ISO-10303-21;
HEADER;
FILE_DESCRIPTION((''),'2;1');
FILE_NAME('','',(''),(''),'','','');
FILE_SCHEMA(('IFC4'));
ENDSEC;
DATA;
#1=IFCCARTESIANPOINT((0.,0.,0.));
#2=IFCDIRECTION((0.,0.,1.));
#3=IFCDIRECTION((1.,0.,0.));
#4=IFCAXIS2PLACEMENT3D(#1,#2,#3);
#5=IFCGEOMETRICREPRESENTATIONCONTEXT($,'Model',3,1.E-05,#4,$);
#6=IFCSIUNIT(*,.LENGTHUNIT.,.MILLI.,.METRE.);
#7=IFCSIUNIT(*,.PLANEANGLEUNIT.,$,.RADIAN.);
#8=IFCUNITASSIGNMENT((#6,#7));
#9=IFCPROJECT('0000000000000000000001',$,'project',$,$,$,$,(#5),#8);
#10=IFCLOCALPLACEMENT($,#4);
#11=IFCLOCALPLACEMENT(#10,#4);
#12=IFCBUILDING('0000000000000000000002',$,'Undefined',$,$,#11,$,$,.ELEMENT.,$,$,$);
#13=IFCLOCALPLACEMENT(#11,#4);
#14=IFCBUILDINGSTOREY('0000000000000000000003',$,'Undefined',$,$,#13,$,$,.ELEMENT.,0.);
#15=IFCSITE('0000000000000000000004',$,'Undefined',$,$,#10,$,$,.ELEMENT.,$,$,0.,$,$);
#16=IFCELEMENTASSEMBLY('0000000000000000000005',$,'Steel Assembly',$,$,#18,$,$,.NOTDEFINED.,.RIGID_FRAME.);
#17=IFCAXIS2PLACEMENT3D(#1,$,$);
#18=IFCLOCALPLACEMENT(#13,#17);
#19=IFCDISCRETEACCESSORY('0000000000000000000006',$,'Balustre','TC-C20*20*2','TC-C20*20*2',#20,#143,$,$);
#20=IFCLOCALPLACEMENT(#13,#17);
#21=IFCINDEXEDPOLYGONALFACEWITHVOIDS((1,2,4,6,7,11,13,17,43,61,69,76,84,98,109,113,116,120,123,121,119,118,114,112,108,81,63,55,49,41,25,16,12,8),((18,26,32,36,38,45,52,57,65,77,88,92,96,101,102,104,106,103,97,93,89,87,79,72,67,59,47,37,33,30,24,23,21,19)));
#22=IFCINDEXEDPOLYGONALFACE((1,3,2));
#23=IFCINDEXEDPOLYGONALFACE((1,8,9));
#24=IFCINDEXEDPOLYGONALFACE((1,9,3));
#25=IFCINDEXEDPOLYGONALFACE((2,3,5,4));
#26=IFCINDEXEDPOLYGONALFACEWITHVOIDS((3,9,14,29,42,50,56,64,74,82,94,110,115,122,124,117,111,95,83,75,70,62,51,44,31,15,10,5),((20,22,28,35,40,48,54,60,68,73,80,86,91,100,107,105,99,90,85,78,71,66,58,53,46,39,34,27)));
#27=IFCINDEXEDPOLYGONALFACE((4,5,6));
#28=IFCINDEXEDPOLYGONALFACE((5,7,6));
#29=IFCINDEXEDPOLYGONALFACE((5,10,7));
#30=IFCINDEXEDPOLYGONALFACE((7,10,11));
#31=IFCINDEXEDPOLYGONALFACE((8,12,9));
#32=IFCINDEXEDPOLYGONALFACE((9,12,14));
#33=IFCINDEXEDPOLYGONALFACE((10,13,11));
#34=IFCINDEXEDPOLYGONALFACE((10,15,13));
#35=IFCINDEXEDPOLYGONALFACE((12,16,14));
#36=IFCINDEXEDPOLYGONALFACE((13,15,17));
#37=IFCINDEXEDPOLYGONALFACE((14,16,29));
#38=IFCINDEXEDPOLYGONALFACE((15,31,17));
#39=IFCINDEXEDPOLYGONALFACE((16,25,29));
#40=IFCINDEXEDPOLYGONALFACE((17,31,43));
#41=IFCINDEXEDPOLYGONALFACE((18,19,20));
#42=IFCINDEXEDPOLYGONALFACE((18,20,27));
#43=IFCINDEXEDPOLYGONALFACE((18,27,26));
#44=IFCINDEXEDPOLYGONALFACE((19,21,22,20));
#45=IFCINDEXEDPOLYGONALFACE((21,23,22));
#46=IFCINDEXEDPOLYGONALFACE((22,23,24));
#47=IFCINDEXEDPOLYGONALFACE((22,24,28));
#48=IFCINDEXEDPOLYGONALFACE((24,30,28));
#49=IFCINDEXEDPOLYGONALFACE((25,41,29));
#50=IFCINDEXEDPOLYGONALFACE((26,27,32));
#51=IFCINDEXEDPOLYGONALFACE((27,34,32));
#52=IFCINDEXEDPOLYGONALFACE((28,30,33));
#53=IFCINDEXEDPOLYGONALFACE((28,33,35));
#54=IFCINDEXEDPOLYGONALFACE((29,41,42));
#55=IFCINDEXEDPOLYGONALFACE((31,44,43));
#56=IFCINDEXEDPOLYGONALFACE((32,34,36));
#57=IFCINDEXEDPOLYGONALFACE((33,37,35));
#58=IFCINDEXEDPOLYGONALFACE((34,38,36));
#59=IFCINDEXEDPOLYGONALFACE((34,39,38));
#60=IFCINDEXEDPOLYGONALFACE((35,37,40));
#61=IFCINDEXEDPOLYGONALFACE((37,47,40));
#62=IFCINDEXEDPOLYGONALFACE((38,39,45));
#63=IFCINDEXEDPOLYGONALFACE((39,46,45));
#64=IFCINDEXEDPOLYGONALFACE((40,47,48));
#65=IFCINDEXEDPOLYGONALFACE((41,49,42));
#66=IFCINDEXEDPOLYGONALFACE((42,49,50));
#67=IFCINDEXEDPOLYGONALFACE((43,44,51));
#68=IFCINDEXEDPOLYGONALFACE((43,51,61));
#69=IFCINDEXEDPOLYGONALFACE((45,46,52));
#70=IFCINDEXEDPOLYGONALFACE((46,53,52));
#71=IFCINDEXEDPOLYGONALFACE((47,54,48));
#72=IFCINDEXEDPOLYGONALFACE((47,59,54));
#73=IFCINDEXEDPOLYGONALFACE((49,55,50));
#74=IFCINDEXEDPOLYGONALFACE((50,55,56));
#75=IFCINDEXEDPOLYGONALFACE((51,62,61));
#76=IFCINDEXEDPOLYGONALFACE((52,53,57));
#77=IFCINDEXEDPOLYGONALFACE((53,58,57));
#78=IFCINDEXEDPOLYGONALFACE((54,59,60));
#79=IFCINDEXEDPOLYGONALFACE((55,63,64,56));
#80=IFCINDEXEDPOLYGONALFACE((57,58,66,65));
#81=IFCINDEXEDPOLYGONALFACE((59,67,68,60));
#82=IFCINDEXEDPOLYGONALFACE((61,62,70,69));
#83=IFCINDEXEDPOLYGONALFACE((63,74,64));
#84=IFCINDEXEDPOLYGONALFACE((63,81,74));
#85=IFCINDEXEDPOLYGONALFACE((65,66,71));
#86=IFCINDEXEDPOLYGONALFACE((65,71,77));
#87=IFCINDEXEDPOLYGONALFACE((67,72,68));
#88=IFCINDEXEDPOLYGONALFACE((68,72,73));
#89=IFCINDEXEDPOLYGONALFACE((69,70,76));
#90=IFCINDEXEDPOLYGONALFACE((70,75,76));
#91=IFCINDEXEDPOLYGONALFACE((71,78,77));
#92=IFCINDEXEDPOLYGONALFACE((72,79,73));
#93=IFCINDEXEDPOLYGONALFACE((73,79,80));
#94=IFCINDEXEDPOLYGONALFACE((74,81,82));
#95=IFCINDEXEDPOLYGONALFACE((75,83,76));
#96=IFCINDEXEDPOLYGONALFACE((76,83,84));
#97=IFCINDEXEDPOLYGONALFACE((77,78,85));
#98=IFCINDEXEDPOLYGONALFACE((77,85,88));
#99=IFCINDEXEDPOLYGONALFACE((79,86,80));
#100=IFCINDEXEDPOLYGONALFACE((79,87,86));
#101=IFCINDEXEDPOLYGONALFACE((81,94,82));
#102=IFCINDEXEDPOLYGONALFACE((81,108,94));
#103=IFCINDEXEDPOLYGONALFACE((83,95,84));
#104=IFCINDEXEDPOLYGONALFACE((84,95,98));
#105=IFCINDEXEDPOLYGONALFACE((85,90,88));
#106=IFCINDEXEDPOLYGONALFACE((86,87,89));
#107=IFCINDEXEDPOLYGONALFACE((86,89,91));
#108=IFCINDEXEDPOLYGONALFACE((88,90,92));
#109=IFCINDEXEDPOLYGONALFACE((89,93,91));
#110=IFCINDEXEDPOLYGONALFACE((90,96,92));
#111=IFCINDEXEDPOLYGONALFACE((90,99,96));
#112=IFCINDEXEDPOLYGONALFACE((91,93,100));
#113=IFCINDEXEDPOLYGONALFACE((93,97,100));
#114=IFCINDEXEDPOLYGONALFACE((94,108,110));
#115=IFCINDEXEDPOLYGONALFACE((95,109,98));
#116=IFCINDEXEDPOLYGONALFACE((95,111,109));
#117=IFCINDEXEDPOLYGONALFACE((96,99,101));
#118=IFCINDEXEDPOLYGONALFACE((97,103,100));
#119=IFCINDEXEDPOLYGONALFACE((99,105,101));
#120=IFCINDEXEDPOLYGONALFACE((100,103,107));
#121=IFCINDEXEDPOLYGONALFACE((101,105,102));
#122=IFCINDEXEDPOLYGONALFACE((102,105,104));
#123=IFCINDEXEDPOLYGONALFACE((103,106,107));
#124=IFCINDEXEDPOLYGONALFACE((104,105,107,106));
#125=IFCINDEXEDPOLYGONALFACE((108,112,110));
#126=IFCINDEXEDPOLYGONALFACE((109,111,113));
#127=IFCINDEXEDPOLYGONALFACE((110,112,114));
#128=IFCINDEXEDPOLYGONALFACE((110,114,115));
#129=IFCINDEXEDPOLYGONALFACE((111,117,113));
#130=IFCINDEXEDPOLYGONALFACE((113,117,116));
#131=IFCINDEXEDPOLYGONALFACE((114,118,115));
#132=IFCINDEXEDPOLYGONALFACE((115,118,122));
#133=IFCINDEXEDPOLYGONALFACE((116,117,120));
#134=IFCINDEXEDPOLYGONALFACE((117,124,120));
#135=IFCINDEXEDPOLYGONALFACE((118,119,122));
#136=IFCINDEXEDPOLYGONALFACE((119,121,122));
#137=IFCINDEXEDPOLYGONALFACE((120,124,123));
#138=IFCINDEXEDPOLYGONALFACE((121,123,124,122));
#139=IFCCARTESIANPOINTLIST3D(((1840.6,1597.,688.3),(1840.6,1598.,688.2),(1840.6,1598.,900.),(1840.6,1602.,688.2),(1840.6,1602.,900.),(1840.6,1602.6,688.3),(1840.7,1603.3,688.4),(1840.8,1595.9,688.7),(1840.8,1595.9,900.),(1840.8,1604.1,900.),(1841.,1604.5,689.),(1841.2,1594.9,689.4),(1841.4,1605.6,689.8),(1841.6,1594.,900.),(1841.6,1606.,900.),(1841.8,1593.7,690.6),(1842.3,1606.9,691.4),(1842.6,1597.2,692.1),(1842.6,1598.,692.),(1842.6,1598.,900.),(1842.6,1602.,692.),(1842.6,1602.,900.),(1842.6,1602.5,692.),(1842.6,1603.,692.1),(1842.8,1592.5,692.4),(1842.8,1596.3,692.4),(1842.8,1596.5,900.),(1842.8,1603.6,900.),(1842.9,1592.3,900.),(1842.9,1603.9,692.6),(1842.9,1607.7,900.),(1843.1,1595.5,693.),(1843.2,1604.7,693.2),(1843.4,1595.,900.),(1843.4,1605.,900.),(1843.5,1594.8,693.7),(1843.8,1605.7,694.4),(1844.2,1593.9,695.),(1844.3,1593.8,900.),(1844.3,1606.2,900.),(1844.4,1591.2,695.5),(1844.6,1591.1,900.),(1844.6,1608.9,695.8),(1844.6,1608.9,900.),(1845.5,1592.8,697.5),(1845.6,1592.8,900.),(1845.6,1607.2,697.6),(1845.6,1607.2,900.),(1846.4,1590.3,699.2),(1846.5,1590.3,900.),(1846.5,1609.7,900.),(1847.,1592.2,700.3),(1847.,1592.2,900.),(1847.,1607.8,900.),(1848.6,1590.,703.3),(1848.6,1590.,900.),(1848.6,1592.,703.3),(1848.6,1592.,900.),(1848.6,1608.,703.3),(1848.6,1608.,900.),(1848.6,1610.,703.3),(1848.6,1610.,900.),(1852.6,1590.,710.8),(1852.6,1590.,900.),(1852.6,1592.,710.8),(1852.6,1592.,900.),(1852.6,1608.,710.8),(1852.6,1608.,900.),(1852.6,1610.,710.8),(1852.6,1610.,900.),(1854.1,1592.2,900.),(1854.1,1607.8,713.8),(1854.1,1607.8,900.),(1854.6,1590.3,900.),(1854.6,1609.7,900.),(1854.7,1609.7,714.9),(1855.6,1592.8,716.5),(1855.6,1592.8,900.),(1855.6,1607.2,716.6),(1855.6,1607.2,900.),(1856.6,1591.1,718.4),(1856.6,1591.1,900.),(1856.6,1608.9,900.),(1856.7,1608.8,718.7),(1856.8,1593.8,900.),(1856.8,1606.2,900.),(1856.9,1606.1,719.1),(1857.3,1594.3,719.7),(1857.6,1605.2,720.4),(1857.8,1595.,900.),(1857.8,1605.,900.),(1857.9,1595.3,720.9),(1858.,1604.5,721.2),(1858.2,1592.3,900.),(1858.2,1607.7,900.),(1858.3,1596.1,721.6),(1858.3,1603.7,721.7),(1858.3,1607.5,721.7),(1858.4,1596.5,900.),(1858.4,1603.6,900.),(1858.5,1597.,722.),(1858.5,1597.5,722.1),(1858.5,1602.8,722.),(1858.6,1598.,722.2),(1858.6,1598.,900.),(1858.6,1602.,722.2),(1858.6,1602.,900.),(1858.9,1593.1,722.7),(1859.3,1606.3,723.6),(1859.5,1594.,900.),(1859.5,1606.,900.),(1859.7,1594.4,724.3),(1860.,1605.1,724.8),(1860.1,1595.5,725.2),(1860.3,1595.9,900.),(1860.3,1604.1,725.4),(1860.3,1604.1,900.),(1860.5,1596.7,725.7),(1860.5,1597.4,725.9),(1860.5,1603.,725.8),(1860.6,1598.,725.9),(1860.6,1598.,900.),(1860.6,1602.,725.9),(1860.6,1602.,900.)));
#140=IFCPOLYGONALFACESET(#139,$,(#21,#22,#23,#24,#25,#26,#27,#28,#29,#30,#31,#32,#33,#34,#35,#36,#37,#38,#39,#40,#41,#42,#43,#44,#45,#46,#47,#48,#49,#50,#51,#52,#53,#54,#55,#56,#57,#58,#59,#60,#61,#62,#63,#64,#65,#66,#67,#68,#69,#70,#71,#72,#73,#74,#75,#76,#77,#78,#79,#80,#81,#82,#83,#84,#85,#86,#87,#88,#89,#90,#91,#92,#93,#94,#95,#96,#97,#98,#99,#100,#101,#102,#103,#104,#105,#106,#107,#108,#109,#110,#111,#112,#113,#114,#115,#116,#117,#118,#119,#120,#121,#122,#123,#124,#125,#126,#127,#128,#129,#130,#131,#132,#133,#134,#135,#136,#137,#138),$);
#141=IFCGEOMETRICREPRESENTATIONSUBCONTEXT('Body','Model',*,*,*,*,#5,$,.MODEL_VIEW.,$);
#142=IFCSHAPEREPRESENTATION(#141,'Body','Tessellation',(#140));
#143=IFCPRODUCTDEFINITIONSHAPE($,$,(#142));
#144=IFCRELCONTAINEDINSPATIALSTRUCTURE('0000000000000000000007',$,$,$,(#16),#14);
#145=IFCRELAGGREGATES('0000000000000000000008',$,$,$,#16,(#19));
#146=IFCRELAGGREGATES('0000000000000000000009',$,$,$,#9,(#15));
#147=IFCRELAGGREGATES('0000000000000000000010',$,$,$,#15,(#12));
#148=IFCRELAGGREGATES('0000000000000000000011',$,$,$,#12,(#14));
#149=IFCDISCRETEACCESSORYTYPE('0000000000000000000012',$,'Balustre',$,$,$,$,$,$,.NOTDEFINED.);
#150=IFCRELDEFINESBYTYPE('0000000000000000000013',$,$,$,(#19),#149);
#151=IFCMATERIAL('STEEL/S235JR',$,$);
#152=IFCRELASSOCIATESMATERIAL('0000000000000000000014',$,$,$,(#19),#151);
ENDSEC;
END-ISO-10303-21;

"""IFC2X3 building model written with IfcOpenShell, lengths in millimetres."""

from ifc_helpers import new_model, si_unit, frame, origin_with_axes, origin_2d_with_axis, place, context, subcontext, project, spatial, hollow_rectangle, extrude, clip, halfspace, material, type_object, element, aggregate, save


model = new_model("IFC2X3")

# Units and contexts
model_context = context("Model", 3, precision=1e-05, world=origin_with_axes())
body_context = subcontext(model_context, "Body", "Model", "MODEL_VIEW")
ifc_project = project(units=[si_unit("LENGTHUNIT", "METRE", prefix="MILLI"), si_unit("PLANEANGLEUNIT", "RADIAN")], contexts=[model_context])

# Site, building, storey
site_placement = place(None, origin_with_axes())
site = spatial("IfcSite", under=ifc_project, at=site_placement, Name="Undefined", CompositionType="ELEMENT", RefElevation=0.0)
building_placement = place(site_placement, origin_with_axes())
building = spatial("IfcBuilding", under=site, at=building_placement, Name="Undefined", CompositionType="ELEMENT")
storey_placement = place(building_placement, origin_with_axes())
storey = spatial("IfcBuildingStorey", under=building, at=storey_placement, Name="Undefined", CompositionType="ELEMENT", Elevation=0.0)

# Element assembly
ifc_material = material(Name="STEEL/S235JR")
assembly_1_placement = place(storey_placement, origin_with_axes())
assembly_1 = element("IfcElementAssembly", 1, at=assembly_1_placement, inside=storey, Name="Steel Assembly", AssemblyPlace="NOTDEFINED", PredefinedType="RIGID_FRAME")

# Discrete accessory
discrete_accessory_type_1 = type_object("IfcDiscreteAccessoryType", Name="Balustre")
discrete_accessory_1_placement = place(assembly_1_placement, frame((1850.6, 1600.0, 900.0), z_axis=(-0.000011, 1.0, 0.0), x_axis=(0.0, 0.0, -1.0)))
discrete_accessory_1 = element("IfcDiscreteAccessory", 2, at=discrete_accessory_1_placement, type_object=discrete_accessory_type_1, material=ifc_material, Name="Balustre", Description="TC-C20*20*2", ObjectType="TC-C20*20*2", context=body_context, shape_type="Clipping", body=[
    clip(extrude(hollow_rectangle(XDim=20.0, YDim=20.0, WallThickness=2.0, InnerFilletRadius=6.0, OuterFilletRadius=8.0, at=origin_2d_with_axis()), frame((212.0, 0.0, 0.0), z_axis=(-1.0, 0.0, 0.0), x_axis=(0.0, -1.0, 0.0)), (0.0, 0.0, 1.0), 212.0), halfspace(frame((221.5, 15.1, 0.0), z_axis=(-0.46842, 0.883506, 0.000005), x_axis=(0.0, -0.000005, 1.0)), True)),
])
aggregate(assembly_1, [discrete_accessory_1])

save(model, "model.ifc")
